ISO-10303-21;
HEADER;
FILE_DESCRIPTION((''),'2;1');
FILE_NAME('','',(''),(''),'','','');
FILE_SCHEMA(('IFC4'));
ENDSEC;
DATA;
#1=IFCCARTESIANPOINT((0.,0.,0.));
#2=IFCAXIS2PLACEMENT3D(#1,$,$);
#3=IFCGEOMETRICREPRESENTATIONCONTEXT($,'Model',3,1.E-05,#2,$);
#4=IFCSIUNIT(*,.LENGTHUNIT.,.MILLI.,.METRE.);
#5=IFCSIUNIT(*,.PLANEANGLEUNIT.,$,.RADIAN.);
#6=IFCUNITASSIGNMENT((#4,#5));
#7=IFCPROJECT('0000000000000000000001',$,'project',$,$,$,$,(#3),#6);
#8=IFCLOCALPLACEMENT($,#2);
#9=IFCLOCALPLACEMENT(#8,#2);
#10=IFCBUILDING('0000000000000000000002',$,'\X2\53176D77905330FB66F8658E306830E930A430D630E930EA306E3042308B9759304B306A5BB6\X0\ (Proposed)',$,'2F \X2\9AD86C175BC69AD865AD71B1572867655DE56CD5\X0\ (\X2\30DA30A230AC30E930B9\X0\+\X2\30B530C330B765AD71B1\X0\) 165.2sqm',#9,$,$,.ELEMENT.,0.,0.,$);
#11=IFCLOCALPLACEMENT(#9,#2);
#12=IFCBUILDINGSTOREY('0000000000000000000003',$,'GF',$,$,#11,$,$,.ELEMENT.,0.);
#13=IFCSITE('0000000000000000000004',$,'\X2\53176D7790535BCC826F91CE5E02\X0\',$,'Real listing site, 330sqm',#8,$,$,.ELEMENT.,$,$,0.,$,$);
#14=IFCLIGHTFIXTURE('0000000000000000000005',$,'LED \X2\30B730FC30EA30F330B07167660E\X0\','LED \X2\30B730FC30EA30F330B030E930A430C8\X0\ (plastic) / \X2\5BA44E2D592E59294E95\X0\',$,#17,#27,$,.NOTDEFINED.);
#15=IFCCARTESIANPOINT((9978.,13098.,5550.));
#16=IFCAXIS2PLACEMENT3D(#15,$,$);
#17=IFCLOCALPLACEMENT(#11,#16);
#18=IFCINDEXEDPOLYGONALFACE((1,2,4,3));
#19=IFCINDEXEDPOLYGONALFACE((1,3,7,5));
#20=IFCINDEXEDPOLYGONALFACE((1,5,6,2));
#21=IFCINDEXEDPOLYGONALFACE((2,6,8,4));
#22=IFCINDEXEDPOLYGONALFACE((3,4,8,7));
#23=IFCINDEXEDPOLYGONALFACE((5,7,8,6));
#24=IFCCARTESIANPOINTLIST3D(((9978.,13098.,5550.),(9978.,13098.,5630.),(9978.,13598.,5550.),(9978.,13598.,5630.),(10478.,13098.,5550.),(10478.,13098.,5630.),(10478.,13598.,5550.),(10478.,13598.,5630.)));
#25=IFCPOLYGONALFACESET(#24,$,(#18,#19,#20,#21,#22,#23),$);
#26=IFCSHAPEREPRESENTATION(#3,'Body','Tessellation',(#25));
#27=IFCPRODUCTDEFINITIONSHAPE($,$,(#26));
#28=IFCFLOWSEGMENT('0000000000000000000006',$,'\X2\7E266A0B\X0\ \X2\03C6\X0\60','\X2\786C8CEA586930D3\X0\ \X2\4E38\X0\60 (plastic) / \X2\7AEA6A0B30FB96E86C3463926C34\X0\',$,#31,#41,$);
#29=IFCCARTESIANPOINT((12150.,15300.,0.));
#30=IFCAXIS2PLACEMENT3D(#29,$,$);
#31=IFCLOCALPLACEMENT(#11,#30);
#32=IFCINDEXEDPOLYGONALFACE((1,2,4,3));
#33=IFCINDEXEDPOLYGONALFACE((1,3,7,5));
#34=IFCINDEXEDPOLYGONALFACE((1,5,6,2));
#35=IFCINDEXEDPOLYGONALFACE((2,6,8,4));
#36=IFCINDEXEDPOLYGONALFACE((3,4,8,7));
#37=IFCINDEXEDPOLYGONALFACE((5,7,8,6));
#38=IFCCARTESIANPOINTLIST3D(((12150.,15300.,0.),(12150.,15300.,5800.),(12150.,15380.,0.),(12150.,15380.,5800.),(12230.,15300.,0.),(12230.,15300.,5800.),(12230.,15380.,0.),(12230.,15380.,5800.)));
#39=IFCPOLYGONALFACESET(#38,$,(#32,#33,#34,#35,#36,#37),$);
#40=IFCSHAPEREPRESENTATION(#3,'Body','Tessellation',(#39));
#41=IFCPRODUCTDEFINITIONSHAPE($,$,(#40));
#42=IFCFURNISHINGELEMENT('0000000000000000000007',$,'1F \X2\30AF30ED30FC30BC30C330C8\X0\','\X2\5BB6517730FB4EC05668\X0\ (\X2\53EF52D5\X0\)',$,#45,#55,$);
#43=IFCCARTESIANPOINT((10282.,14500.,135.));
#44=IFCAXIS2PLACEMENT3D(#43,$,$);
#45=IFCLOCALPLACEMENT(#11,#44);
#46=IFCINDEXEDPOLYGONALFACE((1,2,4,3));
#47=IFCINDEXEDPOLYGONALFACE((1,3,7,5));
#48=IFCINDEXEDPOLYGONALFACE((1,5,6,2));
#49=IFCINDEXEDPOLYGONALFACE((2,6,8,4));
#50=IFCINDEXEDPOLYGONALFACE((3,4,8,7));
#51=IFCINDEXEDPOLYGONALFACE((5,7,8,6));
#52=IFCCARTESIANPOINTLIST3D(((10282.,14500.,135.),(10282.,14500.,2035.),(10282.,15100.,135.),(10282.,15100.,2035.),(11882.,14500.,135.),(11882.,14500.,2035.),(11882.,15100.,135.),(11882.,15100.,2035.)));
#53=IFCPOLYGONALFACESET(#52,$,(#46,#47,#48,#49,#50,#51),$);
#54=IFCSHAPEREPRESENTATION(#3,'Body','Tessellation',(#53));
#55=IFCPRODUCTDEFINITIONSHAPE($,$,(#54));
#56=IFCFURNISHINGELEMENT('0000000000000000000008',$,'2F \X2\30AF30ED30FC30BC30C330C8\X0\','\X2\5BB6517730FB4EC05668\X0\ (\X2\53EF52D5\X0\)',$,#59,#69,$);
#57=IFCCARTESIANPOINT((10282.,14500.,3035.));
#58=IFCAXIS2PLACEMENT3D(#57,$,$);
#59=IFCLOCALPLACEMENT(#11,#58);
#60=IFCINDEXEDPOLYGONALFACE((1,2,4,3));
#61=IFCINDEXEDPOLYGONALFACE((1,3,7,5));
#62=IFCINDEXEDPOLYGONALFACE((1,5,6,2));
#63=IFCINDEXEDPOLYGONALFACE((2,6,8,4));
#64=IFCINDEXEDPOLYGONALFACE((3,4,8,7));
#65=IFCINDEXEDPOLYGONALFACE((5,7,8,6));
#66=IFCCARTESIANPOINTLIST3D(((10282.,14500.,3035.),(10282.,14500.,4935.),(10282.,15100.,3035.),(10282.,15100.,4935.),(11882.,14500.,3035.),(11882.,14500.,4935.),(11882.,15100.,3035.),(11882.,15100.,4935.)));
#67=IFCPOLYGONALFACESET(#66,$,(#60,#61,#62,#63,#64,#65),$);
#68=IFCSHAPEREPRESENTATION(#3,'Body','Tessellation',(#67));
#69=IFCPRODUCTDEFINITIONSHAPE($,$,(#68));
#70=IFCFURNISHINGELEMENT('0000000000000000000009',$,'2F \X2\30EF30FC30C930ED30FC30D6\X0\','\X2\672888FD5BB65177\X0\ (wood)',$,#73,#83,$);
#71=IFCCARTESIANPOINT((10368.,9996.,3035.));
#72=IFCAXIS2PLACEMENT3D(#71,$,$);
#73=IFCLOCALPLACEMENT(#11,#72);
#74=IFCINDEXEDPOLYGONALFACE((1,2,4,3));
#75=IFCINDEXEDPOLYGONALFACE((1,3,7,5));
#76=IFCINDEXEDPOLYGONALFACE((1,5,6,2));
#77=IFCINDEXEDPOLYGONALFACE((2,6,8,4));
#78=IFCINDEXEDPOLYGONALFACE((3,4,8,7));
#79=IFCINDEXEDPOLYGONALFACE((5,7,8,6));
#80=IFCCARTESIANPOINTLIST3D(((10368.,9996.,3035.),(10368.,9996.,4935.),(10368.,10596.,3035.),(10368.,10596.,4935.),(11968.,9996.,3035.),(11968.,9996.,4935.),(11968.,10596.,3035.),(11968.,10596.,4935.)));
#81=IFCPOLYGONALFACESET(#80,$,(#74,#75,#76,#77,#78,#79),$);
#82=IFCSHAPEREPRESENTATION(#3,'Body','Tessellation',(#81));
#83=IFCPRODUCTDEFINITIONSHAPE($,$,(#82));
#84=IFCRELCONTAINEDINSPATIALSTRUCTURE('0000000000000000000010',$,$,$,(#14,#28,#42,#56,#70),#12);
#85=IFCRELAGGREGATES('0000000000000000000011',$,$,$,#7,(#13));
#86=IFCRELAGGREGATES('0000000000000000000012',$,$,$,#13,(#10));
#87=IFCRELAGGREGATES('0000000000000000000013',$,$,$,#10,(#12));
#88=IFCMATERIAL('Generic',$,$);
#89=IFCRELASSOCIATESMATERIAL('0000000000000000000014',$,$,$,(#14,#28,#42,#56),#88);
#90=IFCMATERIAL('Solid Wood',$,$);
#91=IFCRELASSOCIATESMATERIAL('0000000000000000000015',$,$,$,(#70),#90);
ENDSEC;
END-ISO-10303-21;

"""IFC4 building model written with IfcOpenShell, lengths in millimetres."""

from ifc_helpers import new_model, si_unit, frame, frame_2d, origin, place, context, project, spatial, rectangle, extrude, material, element, save


model = new_model("IFC4")

# Units and contexts
model_context = context("Model", 3, precision=1e-05, world=origin())
ifc_project = project(units=[si_unit("LENGTHUNIT", "METRE", prefix="MILLI"), si_unit("PLANEANGLEUNIT", "RADIAN")], contexts=[model_context])

# Site, building, storey
site_placement = place(None, origin())
site = spatial("IfcSite", under=ifc_project, at=site_placement, Name="北海道富良野市", ObjectType="Real listing site, 330sqm", CompositionType="ELEMENT", RefElevation=0.0)
building_placement = place(site_placement, origin())
building = spatial("IfcBuilding", under=site, at=building_placement, Name="北海道・書斎とライブラリのある静かな家 (Proposed)", ObjectType="2F 高気密高断熱在来工法 (ペアガラス+サッシ断熱) 165.2sqm", CompositionType="ELEMENT", ElevationOfRefHeight=0.0, ElevationOfTerrain=0.0)
storey_placement = place(building_placement, origin())
storey = spatial("IfcBuildingStorey", under=building, at=storey_placement, Name="GF", CompositionType="ELEMENT", Elevation=0.0)

# Shared definitions
ifc_material_1 = material(Name="Solid Wood")

# Shared definitions
ifc_material_2 = material(Name="Generic")

# Light fixture
light_fixture_1_placement = place(storey_placement, frame((9978.0, 13098.0, 5550.0)))
element("IfcLightFixture", 1, at=light_fixture_1_placement, inside=storey, material=ifc_material_2, Name="LED シーリング照明", Description="LED シーリングライト (plastic) / 室中央天井", PredefinedType="NOTDEFINED", context=model_context, shape_type="SweptSolid", body=[
    extrude(rectangle(XDim=500.0, YDim=500.0, at=frame_2d((250.0, 250.0))), frame((9978.0, 13098.0, 5550.0)), (0.0, 0.0, 1.0), 80.0),
])

# Flow segment
flow_segment_placement = place(storey_placement, frame((12150.0, 15300.0, 0.0)))
element("IfcFlowSegment", 2, at=flow_segment_placement, inside=storey, material=ifc_material_2, Name="縦樋 φ60", Description="硬質塩ビ 丸60 (plastic) / 竪樋・雨水排水", context=model_context, shape_type="SweptSolid", body=[
    extrude(rectangle(XDim=80.0, YDim=80.0, at=frame_2d((40.0, 40.0))), frame((12150.0, 15300.0, 0.0)), (0.0, 0.0, 1.0), 5800.0),
])

# Furnishing elements
furnishing_1_placement = place(storey_placement, frame((10282.0, 14500.0, 135.0)))
element("IfcFurnishingElement", 3, at=furnishing_1_placement, inside=storey, material=ifc_material_2, Name="1F クローゼット", Description="家具・什器 (可動)", context=model_context, shape_type="SweptSolid", body=[
    extrude(rectangle(XDim=1600.0, YDim=600.0, at=frame_2d((800.0, 300.0))), frame((10282.0, 14500.0, 135.0)), (0.0, 0.0, 1.0), 1900.0),
])
furnishing_2_placement = place(storey_placement, frame((10282.0, 14500.0, 3035.0)))
element("IfcFurnishingElement", 4, at=furnishing_2_placement, inside=storey, material=ifc_material_2, Name="2F クローゼット", Description="家具・什器 (可動)", context=model_context, shape_type="SweptSolid", body=[
    extrude(rectangle(XDim=1600.0, YDim=600.0, at=frame_2d((800.0, 300.0))), frame((10282.0, 14500.0, 3035.0)), (0.0, 0.0, 1.0), 1900.0),
])
furnishing_3_placement = place(storey_placement, frame((10368.0, 9996.0, 3035.0)))
element("IfcFurnishingElement", 5, at=furnishing_3_placement, inside=storey, material=ifc_material_1, Name="2F ワードローブ", Description="木製家具 (wood)", context=model_context, shape_type="SweptSolid", body=[
    extrude(rectangle(XDim=1600.0, YDim=600.0, at=frame_2d((800.0, 300.0))), frame((10368.0, 9996.0, 3035.0)), (0.0, 0.0, 1.0), 1900.0),
])

save(model, "model.ifc")
